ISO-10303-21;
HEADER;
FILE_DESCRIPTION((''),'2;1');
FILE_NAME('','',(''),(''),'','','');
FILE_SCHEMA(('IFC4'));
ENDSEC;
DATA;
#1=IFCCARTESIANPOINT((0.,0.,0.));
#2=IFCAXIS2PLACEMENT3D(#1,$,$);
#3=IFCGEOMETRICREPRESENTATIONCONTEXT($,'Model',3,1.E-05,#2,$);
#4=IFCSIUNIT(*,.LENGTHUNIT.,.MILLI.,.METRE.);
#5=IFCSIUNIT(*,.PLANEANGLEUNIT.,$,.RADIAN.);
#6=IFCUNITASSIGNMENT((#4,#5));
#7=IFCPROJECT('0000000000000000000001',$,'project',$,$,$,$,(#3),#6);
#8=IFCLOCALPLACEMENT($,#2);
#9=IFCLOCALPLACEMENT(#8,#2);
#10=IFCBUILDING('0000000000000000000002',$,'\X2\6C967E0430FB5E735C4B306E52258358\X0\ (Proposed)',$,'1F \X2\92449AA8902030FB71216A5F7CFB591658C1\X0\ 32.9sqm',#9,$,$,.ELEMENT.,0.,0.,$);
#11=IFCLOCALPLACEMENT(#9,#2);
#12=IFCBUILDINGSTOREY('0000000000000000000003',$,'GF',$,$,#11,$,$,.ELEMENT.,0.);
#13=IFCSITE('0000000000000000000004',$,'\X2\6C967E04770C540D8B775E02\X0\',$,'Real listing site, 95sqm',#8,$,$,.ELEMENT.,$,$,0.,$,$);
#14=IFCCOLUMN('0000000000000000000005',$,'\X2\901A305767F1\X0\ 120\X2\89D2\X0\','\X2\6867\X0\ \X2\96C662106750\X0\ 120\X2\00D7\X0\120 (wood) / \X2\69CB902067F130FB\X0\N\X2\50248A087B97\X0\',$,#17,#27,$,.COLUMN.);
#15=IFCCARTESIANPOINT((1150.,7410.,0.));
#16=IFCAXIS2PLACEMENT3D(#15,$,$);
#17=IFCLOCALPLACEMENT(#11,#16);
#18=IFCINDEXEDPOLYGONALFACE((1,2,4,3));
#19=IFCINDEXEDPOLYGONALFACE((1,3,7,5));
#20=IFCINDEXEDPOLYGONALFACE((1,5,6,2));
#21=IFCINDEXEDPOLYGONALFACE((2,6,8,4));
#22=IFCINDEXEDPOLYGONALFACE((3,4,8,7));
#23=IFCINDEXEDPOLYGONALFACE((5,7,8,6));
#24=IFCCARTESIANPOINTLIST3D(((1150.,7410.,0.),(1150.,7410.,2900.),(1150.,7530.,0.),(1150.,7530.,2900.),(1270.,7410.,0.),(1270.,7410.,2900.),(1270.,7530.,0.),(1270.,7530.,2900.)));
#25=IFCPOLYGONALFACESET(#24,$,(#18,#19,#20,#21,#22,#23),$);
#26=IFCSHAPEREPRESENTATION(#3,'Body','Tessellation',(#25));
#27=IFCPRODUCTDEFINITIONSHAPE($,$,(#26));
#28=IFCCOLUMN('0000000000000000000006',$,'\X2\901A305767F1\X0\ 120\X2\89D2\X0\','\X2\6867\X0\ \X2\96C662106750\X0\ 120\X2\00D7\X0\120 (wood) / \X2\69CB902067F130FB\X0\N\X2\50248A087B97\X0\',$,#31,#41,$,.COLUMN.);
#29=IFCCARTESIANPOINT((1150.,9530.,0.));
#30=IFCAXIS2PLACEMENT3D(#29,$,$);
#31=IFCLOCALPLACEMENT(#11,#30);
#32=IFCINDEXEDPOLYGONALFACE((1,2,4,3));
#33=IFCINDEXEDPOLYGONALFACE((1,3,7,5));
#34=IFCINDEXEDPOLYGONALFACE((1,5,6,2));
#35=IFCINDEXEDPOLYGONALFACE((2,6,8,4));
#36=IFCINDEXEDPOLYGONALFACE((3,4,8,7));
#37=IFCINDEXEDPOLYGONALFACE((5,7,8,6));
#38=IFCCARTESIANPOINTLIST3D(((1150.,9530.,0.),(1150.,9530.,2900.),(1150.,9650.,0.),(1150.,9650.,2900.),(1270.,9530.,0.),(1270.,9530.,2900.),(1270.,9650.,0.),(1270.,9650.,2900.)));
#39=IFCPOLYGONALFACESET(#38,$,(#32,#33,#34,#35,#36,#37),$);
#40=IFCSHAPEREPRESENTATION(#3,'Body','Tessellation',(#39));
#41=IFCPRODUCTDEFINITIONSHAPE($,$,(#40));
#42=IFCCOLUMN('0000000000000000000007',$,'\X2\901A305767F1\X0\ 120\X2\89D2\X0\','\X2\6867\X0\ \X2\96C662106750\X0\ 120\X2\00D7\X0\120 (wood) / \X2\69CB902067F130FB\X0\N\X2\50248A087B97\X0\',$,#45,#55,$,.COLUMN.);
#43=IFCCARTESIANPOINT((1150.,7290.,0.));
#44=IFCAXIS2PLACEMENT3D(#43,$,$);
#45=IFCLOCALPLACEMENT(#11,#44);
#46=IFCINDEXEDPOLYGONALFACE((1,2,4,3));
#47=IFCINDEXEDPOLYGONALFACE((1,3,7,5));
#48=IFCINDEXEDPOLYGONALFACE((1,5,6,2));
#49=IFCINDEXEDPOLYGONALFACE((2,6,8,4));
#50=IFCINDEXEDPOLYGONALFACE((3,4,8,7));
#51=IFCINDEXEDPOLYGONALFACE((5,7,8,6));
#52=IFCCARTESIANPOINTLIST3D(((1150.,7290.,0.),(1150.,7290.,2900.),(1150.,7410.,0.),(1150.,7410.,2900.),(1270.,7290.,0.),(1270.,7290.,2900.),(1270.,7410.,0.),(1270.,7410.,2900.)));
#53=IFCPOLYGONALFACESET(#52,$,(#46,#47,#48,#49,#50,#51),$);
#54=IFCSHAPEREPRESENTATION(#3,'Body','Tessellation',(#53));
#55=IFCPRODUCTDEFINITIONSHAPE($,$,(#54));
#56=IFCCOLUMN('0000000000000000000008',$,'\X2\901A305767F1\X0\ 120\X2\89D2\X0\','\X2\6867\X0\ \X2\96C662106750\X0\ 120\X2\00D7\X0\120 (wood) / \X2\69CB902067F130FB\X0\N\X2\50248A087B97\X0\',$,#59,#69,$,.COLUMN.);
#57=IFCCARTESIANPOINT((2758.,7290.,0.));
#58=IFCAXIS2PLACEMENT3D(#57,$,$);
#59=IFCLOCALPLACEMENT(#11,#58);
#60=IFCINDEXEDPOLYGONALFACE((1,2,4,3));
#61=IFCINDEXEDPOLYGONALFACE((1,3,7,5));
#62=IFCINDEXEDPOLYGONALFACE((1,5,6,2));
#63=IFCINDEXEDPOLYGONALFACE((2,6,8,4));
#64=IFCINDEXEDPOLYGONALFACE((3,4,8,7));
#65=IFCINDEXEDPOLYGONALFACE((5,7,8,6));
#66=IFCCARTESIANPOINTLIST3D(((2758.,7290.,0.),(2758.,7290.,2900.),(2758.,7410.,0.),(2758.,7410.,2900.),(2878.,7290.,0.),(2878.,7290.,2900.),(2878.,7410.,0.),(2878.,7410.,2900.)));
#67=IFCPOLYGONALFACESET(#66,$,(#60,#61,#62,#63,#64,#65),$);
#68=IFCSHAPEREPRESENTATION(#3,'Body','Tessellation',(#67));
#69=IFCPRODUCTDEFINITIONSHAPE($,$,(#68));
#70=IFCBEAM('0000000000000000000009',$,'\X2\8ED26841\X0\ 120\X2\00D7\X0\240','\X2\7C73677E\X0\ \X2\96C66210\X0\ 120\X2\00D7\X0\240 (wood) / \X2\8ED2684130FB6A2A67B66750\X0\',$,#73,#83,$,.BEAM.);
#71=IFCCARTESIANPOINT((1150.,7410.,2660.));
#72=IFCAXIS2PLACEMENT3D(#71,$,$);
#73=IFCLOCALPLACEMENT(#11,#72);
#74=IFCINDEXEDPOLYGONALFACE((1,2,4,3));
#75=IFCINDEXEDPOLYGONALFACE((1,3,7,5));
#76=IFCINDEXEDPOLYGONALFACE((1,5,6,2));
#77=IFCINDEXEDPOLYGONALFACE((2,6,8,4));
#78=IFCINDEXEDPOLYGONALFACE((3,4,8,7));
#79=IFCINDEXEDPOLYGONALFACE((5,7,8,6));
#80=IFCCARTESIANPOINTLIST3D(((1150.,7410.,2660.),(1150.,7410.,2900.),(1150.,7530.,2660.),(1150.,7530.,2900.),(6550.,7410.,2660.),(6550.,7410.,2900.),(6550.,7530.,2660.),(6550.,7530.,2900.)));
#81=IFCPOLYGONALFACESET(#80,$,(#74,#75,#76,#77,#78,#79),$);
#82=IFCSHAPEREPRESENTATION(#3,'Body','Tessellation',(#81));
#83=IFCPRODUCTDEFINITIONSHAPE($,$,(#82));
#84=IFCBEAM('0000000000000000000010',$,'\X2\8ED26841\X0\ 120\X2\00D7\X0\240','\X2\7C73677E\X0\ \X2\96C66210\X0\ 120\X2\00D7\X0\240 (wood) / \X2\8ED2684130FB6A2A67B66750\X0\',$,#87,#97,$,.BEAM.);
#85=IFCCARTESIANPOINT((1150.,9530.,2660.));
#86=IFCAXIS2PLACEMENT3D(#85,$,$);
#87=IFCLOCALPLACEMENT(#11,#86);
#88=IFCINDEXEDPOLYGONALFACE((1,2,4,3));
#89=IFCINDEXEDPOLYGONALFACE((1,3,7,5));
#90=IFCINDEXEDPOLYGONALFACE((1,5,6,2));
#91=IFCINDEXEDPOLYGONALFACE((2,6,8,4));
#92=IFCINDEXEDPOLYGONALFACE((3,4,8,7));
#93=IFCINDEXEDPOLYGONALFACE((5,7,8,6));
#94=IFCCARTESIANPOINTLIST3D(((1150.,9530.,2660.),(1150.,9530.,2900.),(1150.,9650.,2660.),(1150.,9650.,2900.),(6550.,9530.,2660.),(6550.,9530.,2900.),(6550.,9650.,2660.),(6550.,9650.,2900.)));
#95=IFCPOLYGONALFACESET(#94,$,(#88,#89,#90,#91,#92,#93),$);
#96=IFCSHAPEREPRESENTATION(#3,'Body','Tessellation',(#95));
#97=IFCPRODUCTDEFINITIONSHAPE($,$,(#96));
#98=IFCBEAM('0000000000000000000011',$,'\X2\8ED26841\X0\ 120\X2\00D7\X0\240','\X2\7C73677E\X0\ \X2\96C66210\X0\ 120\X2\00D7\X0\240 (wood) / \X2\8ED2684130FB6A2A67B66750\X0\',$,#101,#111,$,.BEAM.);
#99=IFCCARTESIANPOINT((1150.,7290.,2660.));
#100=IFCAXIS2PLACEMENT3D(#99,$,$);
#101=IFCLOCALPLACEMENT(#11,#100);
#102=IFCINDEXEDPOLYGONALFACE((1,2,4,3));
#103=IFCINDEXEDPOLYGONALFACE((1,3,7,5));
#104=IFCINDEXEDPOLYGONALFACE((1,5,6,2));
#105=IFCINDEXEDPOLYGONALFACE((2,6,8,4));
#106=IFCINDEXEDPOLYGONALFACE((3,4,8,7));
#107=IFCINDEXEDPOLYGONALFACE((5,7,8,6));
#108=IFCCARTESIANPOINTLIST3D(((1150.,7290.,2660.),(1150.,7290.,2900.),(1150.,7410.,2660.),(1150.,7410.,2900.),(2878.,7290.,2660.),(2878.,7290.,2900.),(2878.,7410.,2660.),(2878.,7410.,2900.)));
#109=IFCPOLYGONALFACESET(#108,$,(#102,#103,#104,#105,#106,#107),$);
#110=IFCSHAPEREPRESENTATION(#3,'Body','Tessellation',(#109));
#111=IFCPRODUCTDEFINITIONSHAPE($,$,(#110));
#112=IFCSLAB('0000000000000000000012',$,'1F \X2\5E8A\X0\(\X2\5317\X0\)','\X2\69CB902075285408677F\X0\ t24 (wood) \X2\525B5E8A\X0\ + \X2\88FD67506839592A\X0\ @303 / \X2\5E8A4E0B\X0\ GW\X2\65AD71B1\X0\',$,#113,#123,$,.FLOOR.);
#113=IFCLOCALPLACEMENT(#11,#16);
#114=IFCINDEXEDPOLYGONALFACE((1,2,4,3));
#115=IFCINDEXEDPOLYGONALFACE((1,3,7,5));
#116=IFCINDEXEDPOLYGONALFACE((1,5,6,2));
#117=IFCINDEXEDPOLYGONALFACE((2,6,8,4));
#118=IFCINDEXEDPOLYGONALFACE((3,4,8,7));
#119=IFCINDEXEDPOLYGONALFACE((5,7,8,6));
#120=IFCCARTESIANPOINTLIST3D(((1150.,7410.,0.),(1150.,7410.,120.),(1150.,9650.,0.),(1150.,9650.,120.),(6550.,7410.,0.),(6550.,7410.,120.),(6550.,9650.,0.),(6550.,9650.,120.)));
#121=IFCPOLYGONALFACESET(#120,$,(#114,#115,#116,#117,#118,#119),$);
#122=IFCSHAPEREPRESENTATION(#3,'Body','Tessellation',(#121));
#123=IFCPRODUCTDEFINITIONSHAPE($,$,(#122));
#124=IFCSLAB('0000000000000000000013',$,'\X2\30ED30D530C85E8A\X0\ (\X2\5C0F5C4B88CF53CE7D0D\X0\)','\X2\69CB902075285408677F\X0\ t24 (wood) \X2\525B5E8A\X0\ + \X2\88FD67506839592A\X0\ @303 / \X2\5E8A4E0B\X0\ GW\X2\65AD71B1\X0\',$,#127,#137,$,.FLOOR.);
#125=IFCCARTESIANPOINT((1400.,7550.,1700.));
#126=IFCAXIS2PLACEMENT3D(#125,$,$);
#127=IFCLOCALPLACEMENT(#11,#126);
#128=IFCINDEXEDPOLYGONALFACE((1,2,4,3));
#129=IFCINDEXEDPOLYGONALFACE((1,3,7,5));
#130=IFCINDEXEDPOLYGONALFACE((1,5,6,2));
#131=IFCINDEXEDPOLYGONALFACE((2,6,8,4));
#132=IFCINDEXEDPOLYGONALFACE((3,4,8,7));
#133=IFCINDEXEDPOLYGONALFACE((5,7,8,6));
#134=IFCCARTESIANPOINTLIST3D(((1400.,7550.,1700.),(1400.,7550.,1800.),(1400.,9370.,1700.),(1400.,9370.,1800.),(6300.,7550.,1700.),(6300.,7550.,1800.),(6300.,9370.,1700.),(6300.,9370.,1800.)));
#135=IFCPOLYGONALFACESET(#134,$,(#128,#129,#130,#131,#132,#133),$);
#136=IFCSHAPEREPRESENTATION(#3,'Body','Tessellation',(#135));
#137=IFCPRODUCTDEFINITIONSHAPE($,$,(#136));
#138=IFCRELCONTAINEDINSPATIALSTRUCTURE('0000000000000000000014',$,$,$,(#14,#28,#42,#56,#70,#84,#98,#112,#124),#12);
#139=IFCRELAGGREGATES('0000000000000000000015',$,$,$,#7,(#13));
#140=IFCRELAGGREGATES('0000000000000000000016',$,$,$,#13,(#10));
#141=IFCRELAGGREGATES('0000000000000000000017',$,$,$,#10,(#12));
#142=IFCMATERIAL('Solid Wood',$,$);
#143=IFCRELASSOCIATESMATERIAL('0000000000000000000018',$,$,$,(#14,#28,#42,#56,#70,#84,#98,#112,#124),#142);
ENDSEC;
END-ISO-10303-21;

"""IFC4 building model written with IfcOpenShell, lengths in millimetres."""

from ifc_helpers import new_model, si_unit, frame, frame_2d, origin, place, context, project, spatial, rectangle, extrude, material, element, save


model = new_model("IFC4")

# Units and contexts
model_context = context("Model", 3, precision=1e-05, world=origin())
ifc_project = project(units=[si_unit("LENGTHUNIT", "METRE", prefix="MILLI"), si_unit("PLANEANGLEUNIT", "RADIAN")], contexts=[model_context])

# Site, building, storey
site_placement = place(None, origin())
site = spatial("IfcSite", under=ifc_project, at=site_placement, Name="沖縄県名護市", ObjectType="Real listing site, 95sqm", CompositionType="ELEMENT", RefElevation=0.0)
building_placement = place(site_placement, origin())
building = spatial("IfcBuilding", under=site, at=building_placement, Name="沖縄・平屋の別荘 (Proposed)", ObjectType="1F 鉄骨造・無機系外壁 32.9sqm", CompositionType="ELEMENT", ElevationOfRefHeight=0.0, ElevationOfTerrain=0.0)
storey_placement = place(building_placement, origin())
storey = spatial("IfcBuildingStorey", under=building, at=storey_placement, Name="GF", CompositionType="ELEMENT", Elevation=0.0)

# Columns
ifc_material_1 = material(Name="Solid Wood")
column_1_placement = place(storey_placement, frame((1150.0, 7410.0, 0.0)))
element("IfcColumn", 1, at=column_1_placement, inside=storey, material=ifc_material_1, Name="通し柱 120角", Description="桧 集成材 120×120 (wood) / 構造柱・N値計算", PredefinedType="COLUMN", context=model_context, shape_type="SweptSolid", body=[
    extrude(rectangle(XDim=120.0, YDim=120.0, at=frame_2d((60.0, 60.0))), frame((1150.0, 7410.0, 0.0)), (0.0, 0.0, 1.0), 2900.0),
])
column_2_placement = place(storey_placement, frame((1150.0, 9530.0, 0.0)))
element("IfcColumn", 2, at=column_2_placement, inside=storey, material=ifc_material_1, Name="通し柱 120角", Description="桧 集成材 120×120 (wood) / 構造柱・N値計算", PredefinedType="COLUMN", context=model_context, shape_type="SweptSolid", body=[
    extrude(rectangle(XDim=120.0, YDim=120.0, at=frame_2d((60.0, 60.0))), frame((1150.0, 9530.0, 0.0)), (0.0, 0.0, 1.0), 2900.0),
])
column_3_placement = place(storey_placement, frame((1150.0, 7290.0, 0.0)))
element("IfcColumn", 3, at=column_3_placement, inside=storey, material=ifc_material_1, Name="通し柱 120角", Description="桧 集成材 120×120 (wood) / 構造柱・N値計算", PredefinedType="COLUMN", context=model_context, shape_type="SweptSolid", body=[
    extrude(rectangle(XDim=120.0, YDim=120.0, at=frame_2d((60.0, 60.0))), frame((1150.0, 7290.0, 0.0)), (0.0, 0.0, 1.0), 2900.0),
])
column_4_placement = place(storey_placement, frame((2758.0, 7290.0, 0.0)))
element("IfcColumn", 4, at=column_4_placement, inside=storey, material=ifc_material_1, Name="通し柱 120角", Description="桧 集成材 120×120 (wood) / 構造柱・N値計算", PredefinedType="COLUMN", context=model_context, shape_type="SweptSolid", body=[
    extrude(rectangle(XDim=120.0, YDim=120.0, at=frame_2d((60.0, 60.0))), frame((2758.0, 7290.0, 0.0)), (0.0, 0.0, 1.0), 2900.0),
])

# Beams
beam_1_placement = place(storey_placement, frame((1150.0, 7410.0, 2660.0)))
element("IfcBeam", 5, at=beam_1_placement, inside=storey, material=ifc_material_1, Name="軒桁 120×240", Description="米松 集成 120×240 (wood) / 軒桁・横架材", PredefinedType="BEAM", context=model_context, shape_type="SweptSolid", body=[
    extrude(rectangle(XDim=5400.0, YDim=120.0, at=frame_2d((2700.0, 60.0))), frame((1150.0, 7410.0, 2660.0)), (0.0, 0.0, 1.0), 240.0),
])
beam_2_placement = place(storey_placement, frame((1150.0, 9530.0, 2660.0)))
element("IfcBeam", 6, at=beam_2_placement, inside=storey, material=ifc_material_1, Name="軒桁 120×240", Description="米松 集成 120×240 (wood) / 軒桁・横架材", PredefinedType="BEAM", context=model_context, shape_type="SweptSolid", body=[
    extrude(rectangle(XDim=5400.0, YDim=120.0, at=frame_2d((2700.0, 60.0))), frame((1150.0, 9530.0, 2660.0)), (0.0, 0.0, 1.0), 240.0),
])
beam_3_placement = place(storey_placement, frame((1150.0, 7290.0, 2660.0)))
element("IfcBeam", 7, at=beam_3_placement, inside=storey, material=ifc_material_1, Name="軒桁 120×240", Description="米松 集成 120×240 (wood) / 軒桁・横架材", PredefinedType="BEAM", context=model_context, shape_type="SweptSolid", body=[
    extrude(rectangle(XDim=1728.0, YDim=120.0, at=frame_2d((864.0, 60.0))), frame((1150.0, 7290.0, 2660.0)), (0.0, 0.0, 1.0), 240.0),
])

# Slabs
slab_1_placement = place(storey_placement, frame((1150.0, 7410.0, 0.0)))
element("IfcSlab", 8, at=slab_1_placement, inside=storey, material=ifc_material_1, Name="1F 床(北)", Description="構造用合板 t24 (wood) 剛床 + 製材根太 @303 / 床下 GW断熱", PredefinedType="FLOOR", context=model_context, shape_type="SweptSolid", body=[
    extrude(rectangle(XDim=5400.0, YDim=2240.0, at=frame_2d((2700.0, 1120.0))), frame((1150.0, 7410.0, 0.0)), (0.0, 0.0, 1.0), 120.0),
])
slab_2_placement = place(storey_placement, frame((1400.0, 7550.0, 1700.0)))
element("IfcSlab", 9, at=slab_2_placement, inside=storey, material=ifc_material_1, Name="ロフト床 (小屋裏収納)", Description="構造用合板 t24 (wood) 剛床 + 製材根太 @303 / 床下 GW断熱", PredefinedType="FLOOR", context=model_context, shape_type="SweptSolid", body=[
    extrude(rectangle(XDim=4900.0, YDim=1820.0, at=frame_2d((2450.0, 910.0))), frame((1400.0, 7550.0, 1700.0)), (0.0, 0.0, 1.0), 100.0),
])

save(model, "model.ifc")
